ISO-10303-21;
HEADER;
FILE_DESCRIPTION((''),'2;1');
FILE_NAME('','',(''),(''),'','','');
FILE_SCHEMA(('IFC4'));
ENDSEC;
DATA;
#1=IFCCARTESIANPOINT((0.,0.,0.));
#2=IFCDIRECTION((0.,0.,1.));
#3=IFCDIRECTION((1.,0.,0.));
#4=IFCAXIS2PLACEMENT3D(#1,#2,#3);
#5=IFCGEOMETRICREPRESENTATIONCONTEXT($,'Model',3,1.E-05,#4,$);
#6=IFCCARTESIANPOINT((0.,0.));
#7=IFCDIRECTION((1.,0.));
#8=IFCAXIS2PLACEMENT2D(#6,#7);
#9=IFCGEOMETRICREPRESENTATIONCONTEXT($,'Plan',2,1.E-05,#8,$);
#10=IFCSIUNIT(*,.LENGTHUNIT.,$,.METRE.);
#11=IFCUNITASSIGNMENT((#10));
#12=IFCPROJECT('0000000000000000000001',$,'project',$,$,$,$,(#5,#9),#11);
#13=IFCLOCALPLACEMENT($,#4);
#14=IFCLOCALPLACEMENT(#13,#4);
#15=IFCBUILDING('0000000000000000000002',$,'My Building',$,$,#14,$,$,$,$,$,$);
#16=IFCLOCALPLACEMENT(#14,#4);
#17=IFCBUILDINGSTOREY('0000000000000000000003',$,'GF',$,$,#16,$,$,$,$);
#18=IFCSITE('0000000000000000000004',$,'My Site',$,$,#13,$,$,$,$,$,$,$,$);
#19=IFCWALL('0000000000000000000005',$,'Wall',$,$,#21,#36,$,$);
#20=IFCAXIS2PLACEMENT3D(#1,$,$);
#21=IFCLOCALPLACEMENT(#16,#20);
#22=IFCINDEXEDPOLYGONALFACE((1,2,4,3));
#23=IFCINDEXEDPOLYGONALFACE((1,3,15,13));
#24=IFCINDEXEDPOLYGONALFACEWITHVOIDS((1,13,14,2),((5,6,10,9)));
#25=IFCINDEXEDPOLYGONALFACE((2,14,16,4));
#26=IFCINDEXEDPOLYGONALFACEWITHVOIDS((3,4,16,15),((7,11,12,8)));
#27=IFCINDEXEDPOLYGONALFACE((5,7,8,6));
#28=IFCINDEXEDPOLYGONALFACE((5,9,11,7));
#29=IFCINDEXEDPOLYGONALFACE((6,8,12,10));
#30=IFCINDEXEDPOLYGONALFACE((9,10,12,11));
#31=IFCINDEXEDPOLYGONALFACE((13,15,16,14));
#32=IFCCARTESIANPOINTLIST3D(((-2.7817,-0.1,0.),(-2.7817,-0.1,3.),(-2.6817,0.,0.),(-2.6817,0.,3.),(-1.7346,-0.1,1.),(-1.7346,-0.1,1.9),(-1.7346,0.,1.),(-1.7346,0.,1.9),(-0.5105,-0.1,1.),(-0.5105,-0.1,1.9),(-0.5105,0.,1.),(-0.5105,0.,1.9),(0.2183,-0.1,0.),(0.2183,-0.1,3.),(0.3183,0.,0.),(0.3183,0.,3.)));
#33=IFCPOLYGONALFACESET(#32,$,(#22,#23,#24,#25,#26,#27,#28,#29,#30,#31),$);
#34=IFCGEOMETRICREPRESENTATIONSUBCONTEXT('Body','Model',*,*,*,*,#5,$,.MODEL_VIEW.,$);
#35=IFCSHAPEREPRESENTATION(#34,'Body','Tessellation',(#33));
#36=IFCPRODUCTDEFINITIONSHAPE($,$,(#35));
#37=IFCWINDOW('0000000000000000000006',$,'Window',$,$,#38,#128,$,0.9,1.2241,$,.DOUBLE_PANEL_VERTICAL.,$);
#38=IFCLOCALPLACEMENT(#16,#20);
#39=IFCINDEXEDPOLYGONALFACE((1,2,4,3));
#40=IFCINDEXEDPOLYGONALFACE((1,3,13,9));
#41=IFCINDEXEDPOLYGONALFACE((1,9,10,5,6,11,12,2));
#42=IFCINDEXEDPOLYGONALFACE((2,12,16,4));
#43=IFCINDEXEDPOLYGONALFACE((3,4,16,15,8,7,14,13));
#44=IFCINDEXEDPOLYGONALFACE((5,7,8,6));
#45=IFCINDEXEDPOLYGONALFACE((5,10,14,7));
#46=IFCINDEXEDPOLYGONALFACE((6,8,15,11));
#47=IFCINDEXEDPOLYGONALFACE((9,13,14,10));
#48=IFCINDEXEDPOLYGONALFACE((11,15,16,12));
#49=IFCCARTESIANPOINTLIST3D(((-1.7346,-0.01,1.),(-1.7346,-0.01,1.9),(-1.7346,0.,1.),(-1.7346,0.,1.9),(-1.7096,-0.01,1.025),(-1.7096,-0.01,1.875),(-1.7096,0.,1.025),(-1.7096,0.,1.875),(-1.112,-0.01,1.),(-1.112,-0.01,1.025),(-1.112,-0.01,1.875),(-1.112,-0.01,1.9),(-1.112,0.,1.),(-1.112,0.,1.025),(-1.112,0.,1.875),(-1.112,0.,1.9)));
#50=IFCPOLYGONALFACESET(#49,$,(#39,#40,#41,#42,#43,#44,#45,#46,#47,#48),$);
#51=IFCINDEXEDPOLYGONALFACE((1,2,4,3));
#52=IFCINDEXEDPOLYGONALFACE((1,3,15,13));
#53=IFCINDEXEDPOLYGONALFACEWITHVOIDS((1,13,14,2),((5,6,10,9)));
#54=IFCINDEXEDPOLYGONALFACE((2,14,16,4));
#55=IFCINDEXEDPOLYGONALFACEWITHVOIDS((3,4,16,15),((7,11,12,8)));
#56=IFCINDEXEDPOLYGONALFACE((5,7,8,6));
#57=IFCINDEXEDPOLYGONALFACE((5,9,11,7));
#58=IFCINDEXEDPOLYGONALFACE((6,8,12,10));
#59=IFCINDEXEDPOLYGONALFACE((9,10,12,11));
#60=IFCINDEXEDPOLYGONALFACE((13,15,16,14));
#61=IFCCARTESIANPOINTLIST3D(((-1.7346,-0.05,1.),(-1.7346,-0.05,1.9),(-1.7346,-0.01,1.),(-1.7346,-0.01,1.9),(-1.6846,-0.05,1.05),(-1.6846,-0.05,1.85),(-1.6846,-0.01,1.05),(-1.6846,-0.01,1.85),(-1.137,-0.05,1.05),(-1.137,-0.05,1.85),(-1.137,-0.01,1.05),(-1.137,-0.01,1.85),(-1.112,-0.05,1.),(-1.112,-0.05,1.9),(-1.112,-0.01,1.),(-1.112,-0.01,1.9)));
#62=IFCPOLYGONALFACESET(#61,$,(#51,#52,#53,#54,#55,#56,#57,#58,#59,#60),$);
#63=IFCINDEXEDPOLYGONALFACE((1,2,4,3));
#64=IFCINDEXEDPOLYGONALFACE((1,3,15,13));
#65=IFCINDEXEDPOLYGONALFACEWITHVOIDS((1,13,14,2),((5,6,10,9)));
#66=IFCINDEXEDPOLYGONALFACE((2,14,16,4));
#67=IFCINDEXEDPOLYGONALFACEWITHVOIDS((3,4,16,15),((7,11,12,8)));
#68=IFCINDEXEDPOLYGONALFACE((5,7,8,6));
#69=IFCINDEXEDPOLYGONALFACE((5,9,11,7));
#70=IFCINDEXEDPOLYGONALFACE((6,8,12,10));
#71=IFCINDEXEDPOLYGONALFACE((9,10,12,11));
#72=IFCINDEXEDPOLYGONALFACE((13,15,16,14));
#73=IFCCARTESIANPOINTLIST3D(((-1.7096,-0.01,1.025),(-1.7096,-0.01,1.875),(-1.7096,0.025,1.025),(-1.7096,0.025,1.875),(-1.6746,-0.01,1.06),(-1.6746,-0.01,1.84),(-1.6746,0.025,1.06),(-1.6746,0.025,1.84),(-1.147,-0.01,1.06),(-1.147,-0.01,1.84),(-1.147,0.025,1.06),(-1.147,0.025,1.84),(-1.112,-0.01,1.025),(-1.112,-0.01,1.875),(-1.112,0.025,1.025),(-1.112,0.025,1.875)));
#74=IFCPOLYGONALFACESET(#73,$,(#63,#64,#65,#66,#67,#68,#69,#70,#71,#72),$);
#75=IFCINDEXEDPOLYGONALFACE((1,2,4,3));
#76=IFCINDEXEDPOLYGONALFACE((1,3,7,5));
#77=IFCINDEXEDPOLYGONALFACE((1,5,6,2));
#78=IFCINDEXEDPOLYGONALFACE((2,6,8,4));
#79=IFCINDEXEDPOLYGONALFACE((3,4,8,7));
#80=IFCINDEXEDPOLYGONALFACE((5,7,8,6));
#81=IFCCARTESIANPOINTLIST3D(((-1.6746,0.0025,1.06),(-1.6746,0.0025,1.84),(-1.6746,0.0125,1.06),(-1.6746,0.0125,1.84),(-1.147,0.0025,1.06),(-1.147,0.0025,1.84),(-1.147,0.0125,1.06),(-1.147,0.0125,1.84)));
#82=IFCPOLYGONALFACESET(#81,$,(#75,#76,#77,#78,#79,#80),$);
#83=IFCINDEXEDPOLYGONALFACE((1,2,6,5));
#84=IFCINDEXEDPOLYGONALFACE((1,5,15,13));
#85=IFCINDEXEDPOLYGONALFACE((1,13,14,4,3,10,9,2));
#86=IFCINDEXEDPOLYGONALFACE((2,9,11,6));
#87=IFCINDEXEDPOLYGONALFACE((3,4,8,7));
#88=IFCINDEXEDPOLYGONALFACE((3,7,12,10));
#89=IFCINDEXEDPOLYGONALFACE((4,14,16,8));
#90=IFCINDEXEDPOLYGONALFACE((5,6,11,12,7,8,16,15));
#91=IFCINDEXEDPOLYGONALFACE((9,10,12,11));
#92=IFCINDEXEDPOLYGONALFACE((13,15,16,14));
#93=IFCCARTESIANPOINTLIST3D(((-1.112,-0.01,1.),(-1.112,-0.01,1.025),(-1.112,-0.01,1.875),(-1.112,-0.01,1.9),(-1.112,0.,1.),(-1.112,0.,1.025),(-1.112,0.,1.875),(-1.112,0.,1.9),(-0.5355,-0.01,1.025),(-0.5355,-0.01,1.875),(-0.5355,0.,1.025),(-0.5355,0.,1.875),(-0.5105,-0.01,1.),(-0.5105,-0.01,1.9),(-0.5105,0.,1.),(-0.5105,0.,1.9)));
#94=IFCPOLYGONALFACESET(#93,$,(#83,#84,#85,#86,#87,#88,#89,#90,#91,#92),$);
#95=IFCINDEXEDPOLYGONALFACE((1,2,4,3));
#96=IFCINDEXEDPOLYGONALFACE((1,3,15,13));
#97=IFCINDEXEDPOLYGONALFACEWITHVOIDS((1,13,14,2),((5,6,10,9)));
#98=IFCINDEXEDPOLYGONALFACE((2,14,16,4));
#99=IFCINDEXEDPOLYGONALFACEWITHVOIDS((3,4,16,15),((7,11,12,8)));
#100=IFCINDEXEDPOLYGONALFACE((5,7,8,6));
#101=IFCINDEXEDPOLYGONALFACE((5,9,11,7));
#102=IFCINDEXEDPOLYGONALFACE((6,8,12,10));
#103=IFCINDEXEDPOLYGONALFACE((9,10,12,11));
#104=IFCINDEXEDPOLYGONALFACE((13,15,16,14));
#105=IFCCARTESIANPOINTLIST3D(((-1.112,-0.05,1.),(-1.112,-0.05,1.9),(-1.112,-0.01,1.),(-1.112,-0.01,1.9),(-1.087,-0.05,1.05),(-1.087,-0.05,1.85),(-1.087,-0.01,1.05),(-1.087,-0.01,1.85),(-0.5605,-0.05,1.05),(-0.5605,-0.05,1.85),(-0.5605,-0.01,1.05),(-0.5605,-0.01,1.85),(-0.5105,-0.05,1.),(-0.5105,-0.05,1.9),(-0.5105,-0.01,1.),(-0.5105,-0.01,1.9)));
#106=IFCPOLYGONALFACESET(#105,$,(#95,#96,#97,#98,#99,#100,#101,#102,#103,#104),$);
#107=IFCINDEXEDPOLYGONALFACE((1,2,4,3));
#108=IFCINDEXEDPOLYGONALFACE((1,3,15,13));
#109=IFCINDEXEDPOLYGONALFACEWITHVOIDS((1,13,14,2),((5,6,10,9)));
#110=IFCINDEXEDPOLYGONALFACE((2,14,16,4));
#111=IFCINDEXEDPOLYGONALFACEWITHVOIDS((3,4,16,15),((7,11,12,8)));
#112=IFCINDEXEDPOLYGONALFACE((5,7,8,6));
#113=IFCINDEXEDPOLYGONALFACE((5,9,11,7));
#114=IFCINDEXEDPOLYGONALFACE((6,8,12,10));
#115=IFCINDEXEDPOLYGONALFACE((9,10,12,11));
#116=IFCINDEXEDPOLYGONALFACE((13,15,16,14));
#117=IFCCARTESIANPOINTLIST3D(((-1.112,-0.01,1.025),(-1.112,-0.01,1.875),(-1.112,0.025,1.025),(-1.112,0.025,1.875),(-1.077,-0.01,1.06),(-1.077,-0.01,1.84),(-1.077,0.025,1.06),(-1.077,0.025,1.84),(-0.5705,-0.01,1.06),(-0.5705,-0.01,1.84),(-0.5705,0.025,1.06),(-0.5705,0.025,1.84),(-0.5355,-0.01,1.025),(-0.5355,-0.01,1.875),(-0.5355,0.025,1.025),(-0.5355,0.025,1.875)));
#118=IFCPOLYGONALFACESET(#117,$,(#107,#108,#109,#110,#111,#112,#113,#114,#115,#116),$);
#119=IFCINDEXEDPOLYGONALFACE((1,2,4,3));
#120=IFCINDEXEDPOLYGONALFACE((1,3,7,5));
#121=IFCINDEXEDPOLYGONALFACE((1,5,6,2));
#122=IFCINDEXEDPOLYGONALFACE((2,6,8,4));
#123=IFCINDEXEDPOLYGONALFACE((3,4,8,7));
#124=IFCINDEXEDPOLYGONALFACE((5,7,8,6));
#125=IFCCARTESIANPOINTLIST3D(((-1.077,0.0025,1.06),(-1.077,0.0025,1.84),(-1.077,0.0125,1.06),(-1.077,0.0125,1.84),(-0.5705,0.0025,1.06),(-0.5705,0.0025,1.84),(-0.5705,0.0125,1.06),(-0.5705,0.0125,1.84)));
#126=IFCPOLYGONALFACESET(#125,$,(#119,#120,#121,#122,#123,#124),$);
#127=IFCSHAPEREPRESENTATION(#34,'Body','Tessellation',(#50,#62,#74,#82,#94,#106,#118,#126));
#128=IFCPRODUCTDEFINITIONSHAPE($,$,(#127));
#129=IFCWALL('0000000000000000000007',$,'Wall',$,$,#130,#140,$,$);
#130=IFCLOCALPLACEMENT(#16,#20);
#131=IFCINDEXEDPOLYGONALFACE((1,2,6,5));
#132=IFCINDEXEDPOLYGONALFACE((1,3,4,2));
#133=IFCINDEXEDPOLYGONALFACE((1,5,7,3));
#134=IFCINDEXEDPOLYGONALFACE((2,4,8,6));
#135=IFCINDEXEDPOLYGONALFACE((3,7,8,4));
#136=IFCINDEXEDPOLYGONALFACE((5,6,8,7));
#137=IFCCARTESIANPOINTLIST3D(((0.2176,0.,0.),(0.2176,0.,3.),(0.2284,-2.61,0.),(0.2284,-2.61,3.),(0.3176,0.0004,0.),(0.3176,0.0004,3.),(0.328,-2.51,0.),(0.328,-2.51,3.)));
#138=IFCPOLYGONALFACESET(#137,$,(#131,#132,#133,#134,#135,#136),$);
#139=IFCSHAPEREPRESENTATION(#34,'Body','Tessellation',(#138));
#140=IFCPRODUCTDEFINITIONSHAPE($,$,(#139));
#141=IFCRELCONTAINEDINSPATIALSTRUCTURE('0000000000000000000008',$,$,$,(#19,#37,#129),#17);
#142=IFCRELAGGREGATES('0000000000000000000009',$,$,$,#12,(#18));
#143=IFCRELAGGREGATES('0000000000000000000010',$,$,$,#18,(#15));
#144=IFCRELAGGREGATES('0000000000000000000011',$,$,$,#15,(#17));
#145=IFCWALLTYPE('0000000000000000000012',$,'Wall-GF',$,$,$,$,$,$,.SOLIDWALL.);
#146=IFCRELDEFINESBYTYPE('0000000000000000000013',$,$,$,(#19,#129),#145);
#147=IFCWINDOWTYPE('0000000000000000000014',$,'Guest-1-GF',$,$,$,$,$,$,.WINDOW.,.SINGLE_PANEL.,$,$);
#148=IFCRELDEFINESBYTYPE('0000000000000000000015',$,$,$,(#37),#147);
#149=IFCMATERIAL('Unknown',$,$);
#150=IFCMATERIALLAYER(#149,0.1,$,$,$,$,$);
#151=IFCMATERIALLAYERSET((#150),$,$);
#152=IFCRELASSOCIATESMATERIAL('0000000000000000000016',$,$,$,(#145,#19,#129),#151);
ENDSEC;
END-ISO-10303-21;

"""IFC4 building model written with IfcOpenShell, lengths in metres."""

from ifc_helpers import new_model, entity, si_unit, frame, origin_with_axes, origin_2d_with_axis, place, context, subcontext, project, spatial, line, indexed_curve, outline, extrude, shape, source, transform, mapped, material, layer, layer_set, layer_usage, type_object, type_shapes, element, fill, save


model = new_model("IFC4")

# Units and contexts
model_context = context("Model", 3, precision=1e-05, world=origin_with_axes())
plan_context = context("Plan", 2, precision=1e-05, world=origin_2d_with_axis())
body_context_1 = subcontext(model_context, "Body", "Model", "MODEL_VIEW")
body_context_2 = subcontext(plan_context, "Body", "Plan", "PLAN_VIEW")
ifc_project = project(units=[si_unit("LENGTHUNIT", "METRE")], contexts=[model_context, plan_context])

# Site, building, storey
site_placement = place(None, origin_with_axes())
site = spatial("IfcSite", under=ifc_project, at=site_placement, Name="My Site")
building_placement = place(site_placement, origin_with_axes())
building = spatial("IfcBuilding", under=site, at=building_placement, Name="My Building")
storey_placement = place(building_placement, origin_with_axes())
storey = spatial("IfcBuildingStorey", under=building, at=storey_placement, Name="GF")

# Shared definitions
ifc_material = material(Name="Unknown")

# Shared definitions
ifc_layer_1 = layer(ifc_material, 0.1)
ifc_layer_set_1 = layer_set([ifc_layer_1])
wall_type = type_object("IfcWallType", Name="Wall-GF", PredefinedType="SOLIDWALL", material=ifc_layer_set_1)

# Wall, opening, window
ifc_layer_usage_1 = layer_usage(ifc_layer_set_1, "AXIS2", "POSITIVE", 0.0)
wall_1_placement = place(storey_placement, frame((-2.7817, -0.1, 0.0), z_axis=(0.0, 0.0, 1.0), x_axis=(1.0, 0.0, 0.0)))
wall_1 = element("IfcWall", 1, at=wall_1_placement, inside=storey, type_object=wall_type, material=ifc_layer_usage_1, Name="Wall", context=body_context_1, shape_type="SweptSolid", body=[
    extrude(outline(indexed_curve([(0.0, 0.0), (0.1, 0.1), (3.1, 0.1), (3.0, 0.0)], segments=[line(1, 2, 3, 4, 1)])), origin_with_axes(), (0.0, 0.0, 1.0), 3.0),
])
shared_shape_1 = source(origin_with_axes(), body_context_1, "Body", "SweptSolid", [
    extrude(outline(indexed_curve([(0.0, 0.0), (1.2241, 0.0), (1.2241, 0.9), (0.0, 0.9)], segments=[line(1, 2, 3, 4, 1)])), frame((0.0, -0.6, 0.0), z_axis=(0.0, -1.0, 0.0), x_axis=(1.0, 0.0, 0.0)), (0.0, 0.0, -1.0), 1.2),
])
opening_1_placement = place(wall_1_placement, frame((1.0471, 0.0, 1.0), z_axis=(0.0, 0.0, 1.0), x_axis=(1.0, 0.0, 0.0)))
opening_1 = element("IfcOpeningElement", 2, at=opening_1_placement, cuts=wall_1, PredefinedType="OPENING", context=body_context_1, shape_type="MappedRepresentation", body=[
    mapped(shared_shape_1, transform((0.0, 0.0, 0.0), x_axis=(1.0, 0.0, 0.0), y_axis=(0.0, 1.0, 0.0), z_axis=(0.0, 0.0, 1.0), scale=1.0)),
])
window_type_1 = type_object("IfcWindowType", Name="Guest-1-GF", PartitioningType="SINGLE_PANEL", PredefinedType="WINDOW")
shared_shape_2 = source(origin_with_axes(), body_context_1, "Body", "SweptSolid", [
    extrude(outline(indexed_curve([(0.6225, 0.0), (0.0, 0.0), (0.0, 0.9), (0.6225, 0.9), (0.6225, 0.875), (0.025, 0.875), (0.025, 0.025), (0.6225, 0.025)], segments=[line(1, 2, 3, 4, 5, 6, 7, 8, 1)])), frame((0.0, 0.09, 0.0), z_axis=(0.0, -1.0, 0.0), x_axis=(1.0, 0.0, 0.0)), (0.0, 0.0, -1.0), 0.01),
    extrude(outline(indexed_curve([(0.0, 0.0), (0.6225, 0.0), (0.6225, 0.9), (0.0, 0.9)], segments=[line(1, 2, 3, 4, 1)]), holes=[indexed_curve([(0.05, 0.05), (0.5975, 0.05), (0.5975, 0.85), (0.05, 0.85)], segments=[line(1, 2, 3, 4, 1)])]), frame((0.0, 0.05, 0.0), z_axis=(0.0, -1.0, 0.0), x_axis=(1.0, 0.0, 0.0)), (0.0, 0.0, -1.0), 0.04),
    extrude(outline(indexed_curve([(0.0, 0.0), (0.5975, 0.0), (0.5975, 0.85), (0.0, 0.85)], segments=[line(1, 2, 3, 4, 1)]), holes=[indexed_curve([(0.035, 0.035), (0.5625, 0.035), (0.5625, 0.815), (0.035, 0.815)], segments=[line(1, 2, 3, 4, 1)])]), frame((0.025, 0.09, 0.025), z_axis=(0.0, -1.0, 0.0), x_axis=(1.0, 0.0, 0.0)), (0.0, 0.0, -1.0), 0.035),
    extrude(outline(indexed_curve([(0.035, 0.035), (0.5625, 0.035), (0.5625, 0.815), (0.035, 0.815)], segments=[line(1, 2, 3, 4, 1)])), frame((0.025, 0.1025, 0.025), z_axis=(0.0, -1.0, 0.0), x_axis=(1.0, 0.0, 0.0)), (0.0, 0.0, -1.0), 0.01),
    extrude(outline(indexed_curve([(0.0, 0.9), (0.6016, 0.9), (0.6016, 0.0), (0.0, 0.0), (0.0, 0.025), (0.5766, 0.025), (0.5766, 0.875), (0.0, 0.875)], segments=[line(1, 2, 3, 4, 5, 6, 7, 8, 1)])), frame((0.6225, 0.09, 0.0), z_axis=(0.0, -1.0, 0.0), x_axis=(1.0, 0.0, 0.0)), (0.0, 0.0, -1.0), 0.01),
    extrude(outline(indexed_curve([(0.0, 0.0), (0.6016, 0.0), (0.6016, 0.9), (0.0, 0.9)], segments=[line(1, 2, 3, 4, 1)]), holes=[indexed_curve([(0.025, 0.05), (0.5516, 0.05), (0.5516, 0.85), (0.025, 0.85)], segments=[line(1, 2, 3, 4, 1)])]), frame((0.6225, 0.05, 0.0), z_axis=(0.0, -1.0, 0.0), x_axis=(1.0, 0.0, 0.0)), (0.0, 0.0, -1.0), 0.04),
    extrude(outline(indexed_curve([(0.0, 0.0), (0.5766, 0.0), (0.5766, 0.85), (0.0, 0.85)], segments=[line(1, 2, 3, 4, 1)]), holes=[indexed_curve([(0.035, 0.035), (0.5416, 0.035), (0.5416, 0.815), (0.035, 0.815)], segments=[line(1, 2, 3, 4, 1)])]), frame((0.6225, 0.09, 0.025), z_axis=(0.0, -1.0, 0.0), x_axis=(1.0, 0.0, 0.0)), (0.0, 0.0, -1.0), 0.035),
    extrude(outline(indexed_curve([(0.035, 0.035), (0.5416, 0.035), (0.5416, 0.815), (0.035, 0.815)], segments=[line(1, 2, 3, 4, 1)])), frame((0.6225, 0.1025, 0.025), z_axis=(0.0, -1.0, 0.0), x_axis=(1.0, 0.0, 0.0)), (0.0, 0.0, -1.0), 0.01),
])
shared_shape_3 = source(origin_with_axes(), body_context_2, "Body", "Curve2D", [
    entity("IfcIndexedPolyCurve", entity("IfcCartesianPointList2D", [[0.05, 0.05], [0.5975, 0.05]])),
    entity("IfcIndexedPolyCurve", entity("IfcCartesianPointList2D", [[0.0, 0.1], [0.025, 0.1], [0.025, 0.09], [0.05, 0.09], [0.05, 0.05], [0.0, 0.05]]), [entity("IfcLineIndex", [1, 2, 3, 4, 5, 6, 1])]),
    entity("IfcIndexedPolyCurve", entity("IfcCartesianPointList2D", [[0.6225, 0.1], [0.6225, 0.1], [0.6225, 0.09], [0.5975, 0.09], [0.5975, 0.05], [0.6225, 0.05]])),
    entity("IfcIndexedPolyCurve", entity("IfcCartesianPointList2D", [[0.025, 0.09], [0.06, 0.09], [0.06, 0.125], [0.025, 0.125]]), [entity("IfcLineIndex", [1, 2, 3, 4, 1])]),
    entity("IfcIndexedPolyCurve", entity("IfcCartesianPointList2D", [[0.6225, 0.09], [0.5875, 0.09], [0.5875, 0.125], [0.6225, 0.125]]), [entity("IfcLineIndex", [1, 2, 3, 4, 1])]),
    entity("IfcIndexedPolyCurve", entity("IfcCartesianPointList2D", [[0.06, 0.09], [0.5875, 0.09]])),
    entity("IfcIndexedPolyCurve", entity("IfcCartesianPointList2D", [[0.06, 0.125], [0.5875, 0.125]])),
    entity("IfcIndexedPolyCurve", entity("IfcCartesianPointList2D", [[0.06, 0.1075], [0.5875, 0.1075]])),
    entity("IfcIndexedPolyCurve", entity("IfcCartesianPointList2D", [[0.6475, 0.05], [1.1741, 0.05]])),
    entity("IfcIndexedPolyCurve", entity("IfcCartesianPointList2D", [[0.6225, 0.1], [0.6225, 0.1], [0.6225, 0.09], [0.6475, 0.09], [0.6475, 0.05], [0.6225, 0.05]])),
    entity("IfcIndexedPolyCurve", entity("IfcCartesianPointList2D", [[1.2241, 0.1], [1.1991, 0.1], [1.1991, 0.09], [1.1741, 0.09], [1.1741, 0.05], [1.2241, 0.05]]), [entity("IfcLineIndex", [1, 2, 3, 4, 5, 6, 1])]),
    entity("IfcIndexedPolyCurve", entity("IfcCartesianPointList2D", [[0.6225, 0.09], [0.6575, 0.09], [0.6575, 0.125], [0.6225, 0.125]]), [entity("IfcLineIndex", [1, 2, 3, 4, 1])]),
    entity("IfcIndexedPolyCurve", entity("IfcCartesianPointList2D", [[1.1991, 0.09], [1.1641, 0.09], [1.1641, 0.125], [1.1991, 0.125]]), [entity("IfcLineIndex", [1, 2, 3, 4, 1])]),
    entity("IfcIndexedPolyCurve", entity("IfcCartesianPointList2D", [[0.6575, 0.09], [1.1641, 0.09]])),
    entity("IfcIndexedPolyCurve", entity("IfcCartesianPointList2D", [[0.6575, 0.125], [1.1641, 0.125]])),
    entity("IfcIndexedPolyCurve", entity("IfcCartesianPointList2D", [[0.6575, 0.1075], [1.1641, 0.1075]])),
])
type_shapes(window_type_1, [shared_shape_2, shared_shape_3])
window_1_placement = place(opening_1_placement, origin_with_axes())
window_1 = element("IfcWindow", 3, at=window_1_placement, inside=storey, type_object=window_type_1, Name="Window", OverallHeight=0.9, OverallWidth=1.2241, PartitioningType="DOUBLE_PANEL_VERTICAL", shapes=[
    shape(body_context_1, "Body", "MappedRepresentation", [mapped(shared_shape_2, transform((0.0, 0.0, 0.0), x_axis=(1.0, 0.0, 0.0), y_axis=(0.0, 1.0, 0.0), z_axis=(0.0, 0.0, 1.0), scale=1.0))]),
    shape(body_context_2, "Body", "MappedRepresentation", [mapped(shared_shape_3, transform((0.0, 0.0, 0.0), x_axis=(1.0, 0.0, 0.0), y_axis=(0.0, 1.0, 0.0), z_axis=(0.0, 0.0, 1.0), scale=1.0))]),
])
fill(opening_1, window_1)

# Wall
ifc_layer_usage_2 = layer_usage(ifc_layer_set_1, "AXIS2", "POSITIVE", 0.0)
wall_2_placement = place(storey_placement, frame((0.2176, 0.0, 0.0), z_axis=(0.0, 0.0, 1.0), x_axis=(0.004129, -0.999991, 0.0)))
element("IfcWall", 4, at=wall_2_placement, inside=storey, type_object=wall_type, material=ifc_layer_usage_2, Name="Wall", context=body_context_1, shape_type="SweptSolid", body=[
    extrude(outline(indexed_curve([(0.0, 0.0), (0.0, 0.1), (2.5104, 0.1), (2.61, 0.0)], segments=[line(1, 2, 3, 4, 1)])), origin_with_axes(), (0.0, 0.0, 1.0), 3.0),
])

save(model, "model.ifc")
